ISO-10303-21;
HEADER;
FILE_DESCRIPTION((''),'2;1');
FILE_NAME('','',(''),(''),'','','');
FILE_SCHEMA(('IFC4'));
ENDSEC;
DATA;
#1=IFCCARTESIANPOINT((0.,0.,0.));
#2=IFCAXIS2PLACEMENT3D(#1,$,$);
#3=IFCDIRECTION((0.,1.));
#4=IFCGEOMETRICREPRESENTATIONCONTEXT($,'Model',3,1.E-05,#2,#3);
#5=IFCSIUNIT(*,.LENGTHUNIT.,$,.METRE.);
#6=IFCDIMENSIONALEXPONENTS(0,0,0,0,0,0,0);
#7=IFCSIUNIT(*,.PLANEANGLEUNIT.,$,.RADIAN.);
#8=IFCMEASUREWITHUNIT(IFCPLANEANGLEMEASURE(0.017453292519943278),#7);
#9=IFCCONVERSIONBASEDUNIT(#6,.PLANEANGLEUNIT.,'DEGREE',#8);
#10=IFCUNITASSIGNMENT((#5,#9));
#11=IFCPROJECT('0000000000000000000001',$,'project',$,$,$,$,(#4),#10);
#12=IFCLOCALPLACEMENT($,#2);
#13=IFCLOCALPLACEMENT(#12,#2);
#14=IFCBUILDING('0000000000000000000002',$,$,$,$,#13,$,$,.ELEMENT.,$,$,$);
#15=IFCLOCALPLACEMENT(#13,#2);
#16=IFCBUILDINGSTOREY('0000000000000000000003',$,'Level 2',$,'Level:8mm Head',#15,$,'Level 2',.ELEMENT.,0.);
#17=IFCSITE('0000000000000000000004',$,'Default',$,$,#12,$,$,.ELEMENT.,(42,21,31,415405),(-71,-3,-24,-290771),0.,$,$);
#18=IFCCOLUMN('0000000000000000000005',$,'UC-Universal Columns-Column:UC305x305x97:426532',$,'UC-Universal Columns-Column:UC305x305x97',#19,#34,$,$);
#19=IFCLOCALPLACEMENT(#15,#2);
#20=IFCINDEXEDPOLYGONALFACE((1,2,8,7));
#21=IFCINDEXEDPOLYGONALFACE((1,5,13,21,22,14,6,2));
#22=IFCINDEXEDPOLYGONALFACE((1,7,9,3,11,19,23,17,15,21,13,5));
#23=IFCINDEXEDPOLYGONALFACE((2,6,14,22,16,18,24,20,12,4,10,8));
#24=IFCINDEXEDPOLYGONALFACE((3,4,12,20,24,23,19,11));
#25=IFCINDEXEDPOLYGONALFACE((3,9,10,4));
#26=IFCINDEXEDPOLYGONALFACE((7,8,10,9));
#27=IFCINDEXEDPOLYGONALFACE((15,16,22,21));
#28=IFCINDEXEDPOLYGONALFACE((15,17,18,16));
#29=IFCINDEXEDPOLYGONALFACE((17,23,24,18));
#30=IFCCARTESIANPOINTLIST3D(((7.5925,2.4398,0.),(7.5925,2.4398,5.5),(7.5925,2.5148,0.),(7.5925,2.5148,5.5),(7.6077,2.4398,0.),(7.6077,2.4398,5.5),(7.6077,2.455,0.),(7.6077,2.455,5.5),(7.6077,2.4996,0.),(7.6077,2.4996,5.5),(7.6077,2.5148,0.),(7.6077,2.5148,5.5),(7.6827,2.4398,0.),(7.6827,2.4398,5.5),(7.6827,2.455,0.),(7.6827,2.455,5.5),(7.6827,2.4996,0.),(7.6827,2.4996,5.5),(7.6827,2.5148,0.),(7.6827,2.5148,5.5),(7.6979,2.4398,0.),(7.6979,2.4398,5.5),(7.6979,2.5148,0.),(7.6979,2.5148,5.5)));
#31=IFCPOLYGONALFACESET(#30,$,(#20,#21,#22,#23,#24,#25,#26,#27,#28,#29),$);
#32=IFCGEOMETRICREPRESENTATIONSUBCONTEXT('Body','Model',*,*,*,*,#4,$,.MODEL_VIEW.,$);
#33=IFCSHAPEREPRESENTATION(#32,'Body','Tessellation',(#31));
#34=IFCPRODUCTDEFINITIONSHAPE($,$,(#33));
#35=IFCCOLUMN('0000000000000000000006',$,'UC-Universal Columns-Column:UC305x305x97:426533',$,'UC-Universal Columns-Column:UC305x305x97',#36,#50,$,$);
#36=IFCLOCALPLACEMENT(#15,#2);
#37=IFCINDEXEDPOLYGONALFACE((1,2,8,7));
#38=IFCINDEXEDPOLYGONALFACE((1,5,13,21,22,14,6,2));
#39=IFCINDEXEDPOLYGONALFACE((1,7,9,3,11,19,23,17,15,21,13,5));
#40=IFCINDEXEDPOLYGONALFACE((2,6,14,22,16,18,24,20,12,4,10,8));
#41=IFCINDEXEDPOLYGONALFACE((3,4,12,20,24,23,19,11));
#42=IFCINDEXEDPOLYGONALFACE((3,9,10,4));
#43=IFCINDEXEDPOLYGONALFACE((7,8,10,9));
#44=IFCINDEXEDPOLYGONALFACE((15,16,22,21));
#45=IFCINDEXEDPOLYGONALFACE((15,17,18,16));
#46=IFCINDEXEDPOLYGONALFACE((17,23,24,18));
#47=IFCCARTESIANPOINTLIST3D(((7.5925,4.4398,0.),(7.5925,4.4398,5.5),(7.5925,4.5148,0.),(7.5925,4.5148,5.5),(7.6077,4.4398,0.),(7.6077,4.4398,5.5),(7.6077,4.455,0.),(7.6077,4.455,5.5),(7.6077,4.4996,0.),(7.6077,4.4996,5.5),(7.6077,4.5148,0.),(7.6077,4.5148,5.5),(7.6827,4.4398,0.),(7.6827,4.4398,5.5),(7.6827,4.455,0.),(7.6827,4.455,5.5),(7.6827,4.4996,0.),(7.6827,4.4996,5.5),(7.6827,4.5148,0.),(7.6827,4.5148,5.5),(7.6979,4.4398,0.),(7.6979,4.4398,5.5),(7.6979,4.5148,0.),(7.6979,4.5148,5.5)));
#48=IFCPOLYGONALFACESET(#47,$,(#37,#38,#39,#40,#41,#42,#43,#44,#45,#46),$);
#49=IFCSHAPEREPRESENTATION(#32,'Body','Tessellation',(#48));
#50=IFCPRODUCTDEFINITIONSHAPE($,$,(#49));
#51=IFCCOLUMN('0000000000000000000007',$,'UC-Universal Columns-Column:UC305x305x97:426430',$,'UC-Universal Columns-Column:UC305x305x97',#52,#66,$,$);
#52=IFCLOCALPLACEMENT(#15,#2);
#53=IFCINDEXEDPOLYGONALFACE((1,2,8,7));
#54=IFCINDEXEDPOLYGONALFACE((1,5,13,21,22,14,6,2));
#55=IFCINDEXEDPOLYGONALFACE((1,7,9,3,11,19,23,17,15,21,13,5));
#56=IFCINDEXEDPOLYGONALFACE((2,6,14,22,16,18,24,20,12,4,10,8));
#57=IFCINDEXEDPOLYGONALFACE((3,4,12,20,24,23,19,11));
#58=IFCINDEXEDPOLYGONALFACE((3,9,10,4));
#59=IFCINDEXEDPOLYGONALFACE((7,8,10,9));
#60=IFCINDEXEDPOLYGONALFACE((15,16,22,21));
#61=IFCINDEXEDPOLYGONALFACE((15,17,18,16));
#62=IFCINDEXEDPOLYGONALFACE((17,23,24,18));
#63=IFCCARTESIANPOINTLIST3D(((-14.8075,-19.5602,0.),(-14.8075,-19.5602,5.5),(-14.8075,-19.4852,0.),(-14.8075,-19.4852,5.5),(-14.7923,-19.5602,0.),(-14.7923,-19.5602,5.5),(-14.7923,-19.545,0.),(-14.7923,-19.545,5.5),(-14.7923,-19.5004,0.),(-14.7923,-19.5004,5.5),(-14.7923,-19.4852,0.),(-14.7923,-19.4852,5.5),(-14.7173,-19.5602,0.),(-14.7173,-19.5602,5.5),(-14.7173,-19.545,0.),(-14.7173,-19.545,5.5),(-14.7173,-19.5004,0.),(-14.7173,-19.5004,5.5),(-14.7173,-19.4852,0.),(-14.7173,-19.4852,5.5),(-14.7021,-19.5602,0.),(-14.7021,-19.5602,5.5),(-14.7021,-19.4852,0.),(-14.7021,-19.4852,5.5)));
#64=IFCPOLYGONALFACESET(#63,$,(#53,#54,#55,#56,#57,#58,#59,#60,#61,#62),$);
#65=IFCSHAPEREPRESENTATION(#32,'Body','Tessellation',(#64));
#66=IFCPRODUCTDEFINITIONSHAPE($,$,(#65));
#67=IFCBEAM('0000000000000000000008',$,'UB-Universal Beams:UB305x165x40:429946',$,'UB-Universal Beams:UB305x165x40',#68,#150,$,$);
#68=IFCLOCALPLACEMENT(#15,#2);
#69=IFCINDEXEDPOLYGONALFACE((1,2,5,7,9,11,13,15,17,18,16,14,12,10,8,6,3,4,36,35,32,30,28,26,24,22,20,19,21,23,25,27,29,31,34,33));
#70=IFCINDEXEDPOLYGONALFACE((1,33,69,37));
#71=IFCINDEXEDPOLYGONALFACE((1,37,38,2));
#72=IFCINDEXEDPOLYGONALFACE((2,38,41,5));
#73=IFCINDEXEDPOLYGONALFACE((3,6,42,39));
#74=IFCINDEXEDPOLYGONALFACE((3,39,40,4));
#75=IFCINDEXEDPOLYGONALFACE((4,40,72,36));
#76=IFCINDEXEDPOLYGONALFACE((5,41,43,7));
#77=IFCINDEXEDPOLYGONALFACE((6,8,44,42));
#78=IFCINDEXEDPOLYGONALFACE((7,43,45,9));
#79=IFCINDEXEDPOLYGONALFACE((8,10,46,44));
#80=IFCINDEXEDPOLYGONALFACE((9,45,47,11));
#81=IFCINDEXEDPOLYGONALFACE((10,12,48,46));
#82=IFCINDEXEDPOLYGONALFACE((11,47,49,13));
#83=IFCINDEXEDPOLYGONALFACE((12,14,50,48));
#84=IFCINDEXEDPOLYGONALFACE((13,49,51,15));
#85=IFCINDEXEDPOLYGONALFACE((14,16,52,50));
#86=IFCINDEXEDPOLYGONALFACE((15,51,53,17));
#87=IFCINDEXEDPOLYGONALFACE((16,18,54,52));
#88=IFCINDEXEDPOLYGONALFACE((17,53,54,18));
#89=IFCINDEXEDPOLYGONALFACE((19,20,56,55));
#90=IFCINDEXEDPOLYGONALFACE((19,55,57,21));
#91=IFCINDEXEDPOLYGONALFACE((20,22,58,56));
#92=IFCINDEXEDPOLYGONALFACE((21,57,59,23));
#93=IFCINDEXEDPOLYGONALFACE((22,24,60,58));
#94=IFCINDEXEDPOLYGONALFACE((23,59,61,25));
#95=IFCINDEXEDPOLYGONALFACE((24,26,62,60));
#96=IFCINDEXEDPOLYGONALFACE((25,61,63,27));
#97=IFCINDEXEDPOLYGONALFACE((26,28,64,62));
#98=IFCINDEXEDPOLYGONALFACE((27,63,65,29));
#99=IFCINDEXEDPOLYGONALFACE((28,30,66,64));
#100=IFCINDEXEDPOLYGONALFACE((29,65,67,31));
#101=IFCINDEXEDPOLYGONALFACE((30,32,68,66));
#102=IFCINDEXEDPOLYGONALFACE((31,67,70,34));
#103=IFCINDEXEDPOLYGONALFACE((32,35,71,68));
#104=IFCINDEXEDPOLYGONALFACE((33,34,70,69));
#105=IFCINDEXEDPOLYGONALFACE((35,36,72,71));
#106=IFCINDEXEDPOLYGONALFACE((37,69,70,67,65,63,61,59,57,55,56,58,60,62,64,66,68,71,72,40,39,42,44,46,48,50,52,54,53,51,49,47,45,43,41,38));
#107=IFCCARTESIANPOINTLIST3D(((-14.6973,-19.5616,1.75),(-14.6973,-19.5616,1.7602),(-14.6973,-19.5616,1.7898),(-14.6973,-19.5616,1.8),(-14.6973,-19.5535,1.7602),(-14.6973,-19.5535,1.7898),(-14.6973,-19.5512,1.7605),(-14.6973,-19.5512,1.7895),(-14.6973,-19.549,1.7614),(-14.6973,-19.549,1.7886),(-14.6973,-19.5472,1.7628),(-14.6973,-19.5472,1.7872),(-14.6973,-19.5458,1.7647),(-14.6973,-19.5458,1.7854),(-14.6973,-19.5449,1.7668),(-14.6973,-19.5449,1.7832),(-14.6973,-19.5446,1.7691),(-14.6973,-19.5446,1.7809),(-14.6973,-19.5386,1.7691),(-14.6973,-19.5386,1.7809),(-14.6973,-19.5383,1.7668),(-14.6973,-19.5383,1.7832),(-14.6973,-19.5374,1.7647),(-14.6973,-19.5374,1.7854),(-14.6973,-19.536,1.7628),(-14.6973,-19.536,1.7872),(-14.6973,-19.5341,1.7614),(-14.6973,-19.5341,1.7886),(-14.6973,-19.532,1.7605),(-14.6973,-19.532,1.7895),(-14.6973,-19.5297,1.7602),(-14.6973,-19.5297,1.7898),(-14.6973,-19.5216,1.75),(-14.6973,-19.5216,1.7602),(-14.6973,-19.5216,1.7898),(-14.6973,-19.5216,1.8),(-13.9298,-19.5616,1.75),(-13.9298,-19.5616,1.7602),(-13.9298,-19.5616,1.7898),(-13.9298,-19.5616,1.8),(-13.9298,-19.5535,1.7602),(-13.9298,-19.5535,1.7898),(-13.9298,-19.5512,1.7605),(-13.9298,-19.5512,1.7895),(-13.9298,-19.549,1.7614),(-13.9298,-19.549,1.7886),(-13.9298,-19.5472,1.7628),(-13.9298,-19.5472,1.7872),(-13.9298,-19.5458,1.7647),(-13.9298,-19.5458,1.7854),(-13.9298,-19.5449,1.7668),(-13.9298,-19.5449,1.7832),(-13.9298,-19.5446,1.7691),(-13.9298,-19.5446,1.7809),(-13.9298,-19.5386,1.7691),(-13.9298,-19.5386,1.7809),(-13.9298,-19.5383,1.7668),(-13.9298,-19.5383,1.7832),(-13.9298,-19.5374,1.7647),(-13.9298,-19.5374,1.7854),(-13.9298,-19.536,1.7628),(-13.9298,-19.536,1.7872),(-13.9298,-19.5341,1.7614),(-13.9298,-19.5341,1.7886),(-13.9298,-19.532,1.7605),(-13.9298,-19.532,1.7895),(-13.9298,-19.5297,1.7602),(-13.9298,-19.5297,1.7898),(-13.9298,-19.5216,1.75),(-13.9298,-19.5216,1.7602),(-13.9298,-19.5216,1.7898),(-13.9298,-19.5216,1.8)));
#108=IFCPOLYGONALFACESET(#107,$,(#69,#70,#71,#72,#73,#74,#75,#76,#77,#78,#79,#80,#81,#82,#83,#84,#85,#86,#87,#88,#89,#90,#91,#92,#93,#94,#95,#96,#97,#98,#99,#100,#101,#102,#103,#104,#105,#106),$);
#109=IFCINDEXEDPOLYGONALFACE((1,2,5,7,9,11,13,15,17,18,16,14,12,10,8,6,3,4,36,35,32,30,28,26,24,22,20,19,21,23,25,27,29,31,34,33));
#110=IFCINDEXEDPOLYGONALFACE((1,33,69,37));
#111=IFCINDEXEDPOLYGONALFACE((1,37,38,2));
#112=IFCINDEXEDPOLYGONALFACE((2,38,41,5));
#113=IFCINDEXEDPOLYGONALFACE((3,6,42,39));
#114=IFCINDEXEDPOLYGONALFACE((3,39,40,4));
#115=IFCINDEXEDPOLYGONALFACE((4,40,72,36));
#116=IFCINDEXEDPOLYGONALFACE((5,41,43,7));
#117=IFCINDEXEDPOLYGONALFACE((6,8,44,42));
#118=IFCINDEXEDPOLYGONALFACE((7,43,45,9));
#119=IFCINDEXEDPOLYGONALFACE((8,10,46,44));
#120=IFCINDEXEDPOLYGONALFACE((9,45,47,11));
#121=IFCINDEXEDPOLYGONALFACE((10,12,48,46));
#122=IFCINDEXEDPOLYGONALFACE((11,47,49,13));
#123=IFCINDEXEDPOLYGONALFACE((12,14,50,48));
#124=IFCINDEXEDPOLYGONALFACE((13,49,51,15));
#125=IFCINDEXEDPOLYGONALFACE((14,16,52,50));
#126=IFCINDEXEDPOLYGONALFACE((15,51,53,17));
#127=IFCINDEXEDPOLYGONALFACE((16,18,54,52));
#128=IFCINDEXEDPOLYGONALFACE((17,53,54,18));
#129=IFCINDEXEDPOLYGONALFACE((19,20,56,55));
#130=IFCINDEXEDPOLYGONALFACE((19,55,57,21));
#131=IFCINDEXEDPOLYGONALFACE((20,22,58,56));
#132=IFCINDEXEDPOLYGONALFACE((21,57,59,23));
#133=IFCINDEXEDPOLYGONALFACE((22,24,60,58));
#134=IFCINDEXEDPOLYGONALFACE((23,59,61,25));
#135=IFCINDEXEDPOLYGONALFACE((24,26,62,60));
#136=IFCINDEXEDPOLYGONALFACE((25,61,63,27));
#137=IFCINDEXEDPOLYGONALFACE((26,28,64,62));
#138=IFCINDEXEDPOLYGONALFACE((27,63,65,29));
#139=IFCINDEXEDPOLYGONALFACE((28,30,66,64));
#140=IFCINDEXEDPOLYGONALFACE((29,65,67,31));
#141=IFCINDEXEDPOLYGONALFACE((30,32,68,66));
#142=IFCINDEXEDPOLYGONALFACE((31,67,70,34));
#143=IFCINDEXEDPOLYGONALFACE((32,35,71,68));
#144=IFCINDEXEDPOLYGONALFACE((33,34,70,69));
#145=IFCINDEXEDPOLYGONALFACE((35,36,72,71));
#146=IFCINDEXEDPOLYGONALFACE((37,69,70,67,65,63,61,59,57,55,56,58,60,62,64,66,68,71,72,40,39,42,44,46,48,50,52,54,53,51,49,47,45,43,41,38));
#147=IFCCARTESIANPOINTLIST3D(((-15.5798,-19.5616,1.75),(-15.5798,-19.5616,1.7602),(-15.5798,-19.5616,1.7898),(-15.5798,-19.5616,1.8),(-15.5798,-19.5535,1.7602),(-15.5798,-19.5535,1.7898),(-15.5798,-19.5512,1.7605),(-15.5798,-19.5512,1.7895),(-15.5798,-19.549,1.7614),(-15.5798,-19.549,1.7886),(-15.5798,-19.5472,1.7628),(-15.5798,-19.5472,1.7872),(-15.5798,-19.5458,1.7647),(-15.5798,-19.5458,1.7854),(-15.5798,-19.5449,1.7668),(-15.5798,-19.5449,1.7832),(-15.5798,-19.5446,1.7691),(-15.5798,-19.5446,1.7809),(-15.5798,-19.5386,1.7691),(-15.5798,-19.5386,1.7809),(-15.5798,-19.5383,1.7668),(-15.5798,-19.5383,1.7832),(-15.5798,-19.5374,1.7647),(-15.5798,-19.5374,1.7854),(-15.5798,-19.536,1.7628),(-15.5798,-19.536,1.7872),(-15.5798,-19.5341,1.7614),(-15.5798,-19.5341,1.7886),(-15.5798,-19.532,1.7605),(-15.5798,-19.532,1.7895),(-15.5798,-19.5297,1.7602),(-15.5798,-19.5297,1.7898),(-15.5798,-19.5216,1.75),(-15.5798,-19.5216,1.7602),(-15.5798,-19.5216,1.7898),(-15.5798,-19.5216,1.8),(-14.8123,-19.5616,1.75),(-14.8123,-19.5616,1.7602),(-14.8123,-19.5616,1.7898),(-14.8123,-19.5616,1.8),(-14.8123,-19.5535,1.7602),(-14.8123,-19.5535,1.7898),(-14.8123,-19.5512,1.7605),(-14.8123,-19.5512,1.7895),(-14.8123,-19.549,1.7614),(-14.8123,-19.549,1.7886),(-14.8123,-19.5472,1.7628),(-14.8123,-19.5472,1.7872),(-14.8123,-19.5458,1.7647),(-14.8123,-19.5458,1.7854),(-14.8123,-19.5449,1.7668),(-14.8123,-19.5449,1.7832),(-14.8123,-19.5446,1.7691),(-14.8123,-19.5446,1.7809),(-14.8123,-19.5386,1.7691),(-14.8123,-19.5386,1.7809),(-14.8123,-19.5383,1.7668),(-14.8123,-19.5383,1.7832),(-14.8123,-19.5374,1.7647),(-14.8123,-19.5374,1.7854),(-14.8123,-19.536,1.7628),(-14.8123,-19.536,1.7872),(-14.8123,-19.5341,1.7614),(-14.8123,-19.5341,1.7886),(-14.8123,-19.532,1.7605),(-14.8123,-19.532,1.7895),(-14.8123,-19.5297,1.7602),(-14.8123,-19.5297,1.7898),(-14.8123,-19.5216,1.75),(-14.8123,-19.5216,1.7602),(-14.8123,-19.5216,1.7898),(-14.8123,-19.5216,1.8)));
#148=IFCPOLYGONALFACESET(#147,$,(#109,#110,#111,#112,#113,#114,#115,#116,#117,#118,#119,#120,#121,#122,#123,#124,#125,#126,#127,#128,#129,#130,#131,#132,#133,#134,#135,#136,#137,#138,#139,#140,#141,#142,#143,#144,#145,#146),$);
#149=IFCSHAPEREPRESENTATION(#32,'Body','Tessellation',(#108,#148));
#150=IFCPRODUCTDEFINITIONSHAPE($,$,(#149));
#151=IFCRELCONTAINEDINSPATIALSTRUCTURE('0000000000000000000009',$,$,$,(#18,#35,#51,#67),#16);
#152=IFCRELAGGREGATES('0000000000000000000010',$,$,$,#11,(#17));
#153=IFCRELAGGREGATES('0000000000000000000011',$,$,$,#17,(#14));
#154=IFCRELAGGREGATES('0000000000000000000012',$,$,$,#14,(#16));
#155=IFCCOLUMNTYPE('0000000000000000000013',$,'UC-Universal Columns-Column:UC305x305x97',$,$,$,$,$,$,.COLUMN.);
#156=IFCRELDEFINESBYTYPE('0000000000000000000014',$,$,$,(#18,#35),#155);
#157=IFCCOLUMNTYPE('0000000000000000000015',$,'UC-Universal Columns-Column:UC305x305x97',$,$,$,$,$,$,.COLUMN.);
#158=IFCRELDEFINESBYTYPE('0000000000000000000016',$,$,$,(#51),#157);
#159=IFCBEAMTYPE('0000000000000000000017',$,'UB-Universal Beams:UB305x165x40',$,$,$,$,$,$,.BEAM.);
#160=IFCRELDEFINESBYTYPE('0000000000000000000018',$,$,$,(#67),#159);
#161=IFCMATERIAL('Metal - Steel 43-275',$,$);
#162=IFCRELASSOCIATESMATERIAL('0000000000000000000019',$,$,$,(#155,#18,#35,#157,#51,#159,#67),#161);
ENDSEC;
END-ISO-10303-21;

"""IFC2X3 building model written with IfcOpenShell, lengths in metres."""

from ifc_helpers import new_model, entity, si_unit, converted_unit, direction, frame, frame_2d, origin, place, context, subcontext, project, spatial, polyline, circle_curve, parameter, trimmed, segment, composite_curve, i_section, outline, extrude, source, transform, mapped, material, type_object, type_shapes, element, save


model = new_model("IFC2X3")

# Units and contexts
model_context = context("Model", 3, precision=1e-05, world=origin(), true_north=direction((0.0, 1.0)))
body_context = subcontext(model_context, "Body", "Model", "MODEL_VIEW")
ifc_project = project(units=[si_unit("LENGTHUNIT", "METRE"), converted_unit("PLANEANGLEUNIT", "DEGREE", entity("IfcPlaneAngleMeasure", 0.017453292519943278), si_unit("PLANEANGLEUNIT", "RADIAN"), dimensions=[0, 0, 0, 0, 0, 0, 0])], contexts=[model_context])

# Site, building, storey
site_placement = place(None, origin())
site = spatial("IfcSite", under=ifc_project, at=site_placement, Name="Default", CompositionType="ELEMENT", RefLatitude=(42, 21, 31, 415405), RefLongitude=(-71, -3, -24, -290771), RefElevation=0.0)
building_placement = place(site_placement, origin())
building = spatial("IfcBuilding", under=site, at=building_placement, CompositionType="ELEMENT")
storey_placement = place(building_placement, origin())
storey = spatial("IfcBuildingStorey", under=building, at=storey_placement, Name="Level 2", ObjectType="Level:8mm Head", LongName="Level 2", CompositionType="ELEMENT", Elevation=0.0)

# Columns
ifc_material_1 = material(Name="Metal - Steel 43-275")
column_type_1 = type_object("IfcColumnType", Name="UC-Universal Columns-Column:UC305x305x97", PredefinedType="COLUMN", material=ifc_material_1)
shared_shape_1 = source(origin(), body_context, "Body", "SweptSolid", [
    extrude(outline(composite_curve([segment(polyline([(-0.0375, -0.0375), (0.0375, -0.0375)]), True, "CONTINUOUS"), segment(polyline([(0.0375, -0.0375), (0.0527, -0.0375)]), True, "CONTINUOUS"), segment(trimmed(circle_curve(frame_2d((0.0527, -0.0223), x_axis=(-1.0, 0.0)), 0.0152), [parameter(0.0)], [parameter(90.0)], True, "PARAMETER"), False, "CONTINUOUS"), segment(polyline([(0.0375, -0.0223), (0.0375, 0.0223)]), True, "CONTINUOUS"), segment(trimmed(circle_curve(frame_2d((0.0527, 0.0223), x_axis=(-1.0, 0.0)), 0.0152), [parameter(270.0)], [parameter(0.0)], True, "PARAMETER"), False, "CONTINUOUS"), segment(polyline([(0.0527, 0.0375), (0.0375, 0.0375)]), True, "CONTINUOUS"), segment(polyline([(0.0375, 0.0375), (-0.0375, 0.0375)]), True, "CONTINUOUS"), segment(polyline([(-0.0375, 0.0375), (-0.0527, 0.0375)]), True, "CONTINUOUS"), segment(trimmed(circle_curve(frame_2d((-0.0527, 0.0223), x_axis=(-1.0, 0.0)), 0.0152), [parameter(180.0)], [parameter(270.0)], True, "PARAMETER"), False, "CONTINUOUS"), segment(polyline([(-0.0375, 0.0223), (-0.0375, -0.0223)]), True, "CONTINUOUS"), segment(trimmed(circle_curve(frame_2d((-0.0527, -0.0223), x_axis=(-1.0, 0.0)), 0.0152), [parameter(90.0)], [parameter(180.0)], True, "PARAMETER"), False, "CONTINUOUS"), segment(polyline([(-0.0527, -0.0375), (-0.0375, -0.0375)]), True, "CONTINUOUS")], self_intersect=False)), frame((0.0, 0.0, 0.0), z_axis=(0.0, 0.0, 1.0), x_axis=(-1.0, 0.0, 0.0)), (0.0, 0.0, 1.0), 5.5),
])
type_shapes(column_type_1, [shared_shape_1])
for number, where, z_axis, x_axis, name in (
    (1, (7.6452, 2.4773, 0.0), (0.0, 0.0, 1.0), (-1.0, 0.0, 0.0), "UC-Universal Columns-Column:UC305x305x97:426532"),
    (2, (7.6452, 4.4773, 0.0), (0.0, 0.0, 1.0), (-1.0, 0.0, 0.0), "UC-Universal Columns-Column:UC305x305x97:426533"),
):
    element("IfcColumn", number, at=place(storey_placement, frame(where, z_axis=z_axis, x_axis=x_axis)), inside=storey, type_object=column_type_1, material=ifc_material_1, Name=name, ObjectType="UC-Universal Columns-Column:UC305x305x97", context=body_context, shape_type="MappedRepresentation", body=[
        mapped(shared_shape_1, transform((0.0, 0.0, 0.0), scale=1.0)),
    ])
column_type_2 = type_object("IfcColumnType", Name="UC-Universal Columns-Column:UC305x305x97", PredefinedType="COLUMN", material=ifc_material_1)
shared_shape_2 = source(origin(), body_context, "Body", "SweptSolid", [
    extrude(outline(composite_curve([segment(polyline([(-0.0375, -0.0375), (0.0375, -0.0375)]), True, "CONTINUOUS"), segment(polyline([(0.0375, -0.0375), (0.0527, -0.0375)]), True, "CONTINUOUS"), segment(trimmed(circle_curve(frame_2d((0.0527, -0.0223), x_axis=(-1.0, 0.0)), 0.0152), [parameter(0.0)], [parameter(90.0)], True, "PARAMETER"), False, "CONTINUOUS"), segment(polyline([(0.0375, -0.0223), (0.0375, 0.0223)]), True, "CONTINUOUS"), segment(trimmed(circle_curve(frame_2d((0.0527, 0.0223), x_axis=(-1.0, 0.0)), 0.0152), [parameter(270.0)], [parameter(0.0)], True, "PARAMETER"), False, "CONTINUOUS"), segment(polyline([(0.0527, 0.0375), (0.0375, 0.0375)]), True, "CONTINUOUS"), segment(polyline([(0.0375, 0.0375), (-0.0375, 0.0375)]), True, "CONTINUOUS"), segment(polyline([(-0.0375, 0.0375), (-0.0527, 0.0375)]), True, "CONTINUOUS"), segment(trimmed(circle_curve(frame_2d((-0.0527, 0.0223), x_axis=(-1.0, 0.0)), 0.0152), [parameter(180.0)], [parameter(270.0)], True, "PARAMETER"), False, "CONTINUOUS"), segment(polyline([(-0.0375, 0.0223), (-0.0375, -0.0223)]), True, "CONTINUOUS"), segment(trimmed(circle_curve(frame_2d((-0.0527, -0.0223), x_axis=(-1.0, 0.0)), 0.0152), [parameter(90.0)], [parameter(180.0)], True, "PARAMETER"), False, "CONTINUOUS"), segment(polyline([(-0.0527, -0.0375), (-0.0375, -0.0375)]), True, "CONTINUOUS")], self_intersect=False)), frame((-14.7548, -19.5227, 0.0)), (0.0, 0.0, 1.0), 5.5),
])
type_shapes(column_type_2, [shared_shape_2])
column_placement = place(storey_placement, origin())
element("IfcColumn", 3, at=column_placement, inside=storey, type_object=column_type_2, material=ifc_material_1, Name="UC-Universal Columns-Column:UC305x305x97:426430", ObjectType="UC-Universal Columns-Column:UC305x305x97", context=body_context, shape_type="MappedRepresentation", body=[
    mapped(shared_shape_2, transform((0.0, 0.0, 0.0), scale=1.0)),
])

# Beam
beam_type = type_object("IfcBeamType", Name="UB-Universal Beams:UB305x165x40", PredefinedType="BEAM", material=ifc_material_1)
shared_shape_3 = source(origin(), body_context, "Body", "SweptSolid", [
    extrude(i_section(OverallWidth=0.04, OverallDepth=0.05, WebThickness=0.006, FlangeThickness=0.0102, FilletRadius=0.0089, at=frame_2d((0.0, 0.0), x_axis=(0.0, 1.0))), frame((-14.6973, -19.5416, 1.775), z_axis=(1.0, 0.0, 0.0), x_axis=(0.0, 0.0, -1.0)), (0.0, 0.0, 1.0), 0.7675),
    extrude(i_section(OverallWidth=0.04, OverallDepth=0.05, WebThickness=0.006, FlangeThickness=0.0102, FilletRadius=0.0089, at=frame_2d((0.0, 0.0), x_axis=(0.0, 1.0))), frame((-15.5798, -19.5416, 1.775), z_axis=(1.0, 0.0, 0.0), x_axis=(0.0, 0.0, -1.0)), (0.0, 0.0, 1.0), 0.7675),
])
type_shapes(beam_type, [shared_shape_3])
beam_1_placement = place(storey_placement, origin())
element("IfcBeam", 4, at=beam_1_placement, inside=storey, type_object=beam_type, material=ifc_material_1, Name="UB-Universal Beams:UB305x165x40:429946", ObjectType="UB-Universal Beams:UB305x165x40", context=body_context, shape_type="MappedRepresentation", body=[
    mapped(shared_shape_3, transform((0.0, 0.0, 0.0), scale=1.0)),
])

save(model, "model.ifc")
